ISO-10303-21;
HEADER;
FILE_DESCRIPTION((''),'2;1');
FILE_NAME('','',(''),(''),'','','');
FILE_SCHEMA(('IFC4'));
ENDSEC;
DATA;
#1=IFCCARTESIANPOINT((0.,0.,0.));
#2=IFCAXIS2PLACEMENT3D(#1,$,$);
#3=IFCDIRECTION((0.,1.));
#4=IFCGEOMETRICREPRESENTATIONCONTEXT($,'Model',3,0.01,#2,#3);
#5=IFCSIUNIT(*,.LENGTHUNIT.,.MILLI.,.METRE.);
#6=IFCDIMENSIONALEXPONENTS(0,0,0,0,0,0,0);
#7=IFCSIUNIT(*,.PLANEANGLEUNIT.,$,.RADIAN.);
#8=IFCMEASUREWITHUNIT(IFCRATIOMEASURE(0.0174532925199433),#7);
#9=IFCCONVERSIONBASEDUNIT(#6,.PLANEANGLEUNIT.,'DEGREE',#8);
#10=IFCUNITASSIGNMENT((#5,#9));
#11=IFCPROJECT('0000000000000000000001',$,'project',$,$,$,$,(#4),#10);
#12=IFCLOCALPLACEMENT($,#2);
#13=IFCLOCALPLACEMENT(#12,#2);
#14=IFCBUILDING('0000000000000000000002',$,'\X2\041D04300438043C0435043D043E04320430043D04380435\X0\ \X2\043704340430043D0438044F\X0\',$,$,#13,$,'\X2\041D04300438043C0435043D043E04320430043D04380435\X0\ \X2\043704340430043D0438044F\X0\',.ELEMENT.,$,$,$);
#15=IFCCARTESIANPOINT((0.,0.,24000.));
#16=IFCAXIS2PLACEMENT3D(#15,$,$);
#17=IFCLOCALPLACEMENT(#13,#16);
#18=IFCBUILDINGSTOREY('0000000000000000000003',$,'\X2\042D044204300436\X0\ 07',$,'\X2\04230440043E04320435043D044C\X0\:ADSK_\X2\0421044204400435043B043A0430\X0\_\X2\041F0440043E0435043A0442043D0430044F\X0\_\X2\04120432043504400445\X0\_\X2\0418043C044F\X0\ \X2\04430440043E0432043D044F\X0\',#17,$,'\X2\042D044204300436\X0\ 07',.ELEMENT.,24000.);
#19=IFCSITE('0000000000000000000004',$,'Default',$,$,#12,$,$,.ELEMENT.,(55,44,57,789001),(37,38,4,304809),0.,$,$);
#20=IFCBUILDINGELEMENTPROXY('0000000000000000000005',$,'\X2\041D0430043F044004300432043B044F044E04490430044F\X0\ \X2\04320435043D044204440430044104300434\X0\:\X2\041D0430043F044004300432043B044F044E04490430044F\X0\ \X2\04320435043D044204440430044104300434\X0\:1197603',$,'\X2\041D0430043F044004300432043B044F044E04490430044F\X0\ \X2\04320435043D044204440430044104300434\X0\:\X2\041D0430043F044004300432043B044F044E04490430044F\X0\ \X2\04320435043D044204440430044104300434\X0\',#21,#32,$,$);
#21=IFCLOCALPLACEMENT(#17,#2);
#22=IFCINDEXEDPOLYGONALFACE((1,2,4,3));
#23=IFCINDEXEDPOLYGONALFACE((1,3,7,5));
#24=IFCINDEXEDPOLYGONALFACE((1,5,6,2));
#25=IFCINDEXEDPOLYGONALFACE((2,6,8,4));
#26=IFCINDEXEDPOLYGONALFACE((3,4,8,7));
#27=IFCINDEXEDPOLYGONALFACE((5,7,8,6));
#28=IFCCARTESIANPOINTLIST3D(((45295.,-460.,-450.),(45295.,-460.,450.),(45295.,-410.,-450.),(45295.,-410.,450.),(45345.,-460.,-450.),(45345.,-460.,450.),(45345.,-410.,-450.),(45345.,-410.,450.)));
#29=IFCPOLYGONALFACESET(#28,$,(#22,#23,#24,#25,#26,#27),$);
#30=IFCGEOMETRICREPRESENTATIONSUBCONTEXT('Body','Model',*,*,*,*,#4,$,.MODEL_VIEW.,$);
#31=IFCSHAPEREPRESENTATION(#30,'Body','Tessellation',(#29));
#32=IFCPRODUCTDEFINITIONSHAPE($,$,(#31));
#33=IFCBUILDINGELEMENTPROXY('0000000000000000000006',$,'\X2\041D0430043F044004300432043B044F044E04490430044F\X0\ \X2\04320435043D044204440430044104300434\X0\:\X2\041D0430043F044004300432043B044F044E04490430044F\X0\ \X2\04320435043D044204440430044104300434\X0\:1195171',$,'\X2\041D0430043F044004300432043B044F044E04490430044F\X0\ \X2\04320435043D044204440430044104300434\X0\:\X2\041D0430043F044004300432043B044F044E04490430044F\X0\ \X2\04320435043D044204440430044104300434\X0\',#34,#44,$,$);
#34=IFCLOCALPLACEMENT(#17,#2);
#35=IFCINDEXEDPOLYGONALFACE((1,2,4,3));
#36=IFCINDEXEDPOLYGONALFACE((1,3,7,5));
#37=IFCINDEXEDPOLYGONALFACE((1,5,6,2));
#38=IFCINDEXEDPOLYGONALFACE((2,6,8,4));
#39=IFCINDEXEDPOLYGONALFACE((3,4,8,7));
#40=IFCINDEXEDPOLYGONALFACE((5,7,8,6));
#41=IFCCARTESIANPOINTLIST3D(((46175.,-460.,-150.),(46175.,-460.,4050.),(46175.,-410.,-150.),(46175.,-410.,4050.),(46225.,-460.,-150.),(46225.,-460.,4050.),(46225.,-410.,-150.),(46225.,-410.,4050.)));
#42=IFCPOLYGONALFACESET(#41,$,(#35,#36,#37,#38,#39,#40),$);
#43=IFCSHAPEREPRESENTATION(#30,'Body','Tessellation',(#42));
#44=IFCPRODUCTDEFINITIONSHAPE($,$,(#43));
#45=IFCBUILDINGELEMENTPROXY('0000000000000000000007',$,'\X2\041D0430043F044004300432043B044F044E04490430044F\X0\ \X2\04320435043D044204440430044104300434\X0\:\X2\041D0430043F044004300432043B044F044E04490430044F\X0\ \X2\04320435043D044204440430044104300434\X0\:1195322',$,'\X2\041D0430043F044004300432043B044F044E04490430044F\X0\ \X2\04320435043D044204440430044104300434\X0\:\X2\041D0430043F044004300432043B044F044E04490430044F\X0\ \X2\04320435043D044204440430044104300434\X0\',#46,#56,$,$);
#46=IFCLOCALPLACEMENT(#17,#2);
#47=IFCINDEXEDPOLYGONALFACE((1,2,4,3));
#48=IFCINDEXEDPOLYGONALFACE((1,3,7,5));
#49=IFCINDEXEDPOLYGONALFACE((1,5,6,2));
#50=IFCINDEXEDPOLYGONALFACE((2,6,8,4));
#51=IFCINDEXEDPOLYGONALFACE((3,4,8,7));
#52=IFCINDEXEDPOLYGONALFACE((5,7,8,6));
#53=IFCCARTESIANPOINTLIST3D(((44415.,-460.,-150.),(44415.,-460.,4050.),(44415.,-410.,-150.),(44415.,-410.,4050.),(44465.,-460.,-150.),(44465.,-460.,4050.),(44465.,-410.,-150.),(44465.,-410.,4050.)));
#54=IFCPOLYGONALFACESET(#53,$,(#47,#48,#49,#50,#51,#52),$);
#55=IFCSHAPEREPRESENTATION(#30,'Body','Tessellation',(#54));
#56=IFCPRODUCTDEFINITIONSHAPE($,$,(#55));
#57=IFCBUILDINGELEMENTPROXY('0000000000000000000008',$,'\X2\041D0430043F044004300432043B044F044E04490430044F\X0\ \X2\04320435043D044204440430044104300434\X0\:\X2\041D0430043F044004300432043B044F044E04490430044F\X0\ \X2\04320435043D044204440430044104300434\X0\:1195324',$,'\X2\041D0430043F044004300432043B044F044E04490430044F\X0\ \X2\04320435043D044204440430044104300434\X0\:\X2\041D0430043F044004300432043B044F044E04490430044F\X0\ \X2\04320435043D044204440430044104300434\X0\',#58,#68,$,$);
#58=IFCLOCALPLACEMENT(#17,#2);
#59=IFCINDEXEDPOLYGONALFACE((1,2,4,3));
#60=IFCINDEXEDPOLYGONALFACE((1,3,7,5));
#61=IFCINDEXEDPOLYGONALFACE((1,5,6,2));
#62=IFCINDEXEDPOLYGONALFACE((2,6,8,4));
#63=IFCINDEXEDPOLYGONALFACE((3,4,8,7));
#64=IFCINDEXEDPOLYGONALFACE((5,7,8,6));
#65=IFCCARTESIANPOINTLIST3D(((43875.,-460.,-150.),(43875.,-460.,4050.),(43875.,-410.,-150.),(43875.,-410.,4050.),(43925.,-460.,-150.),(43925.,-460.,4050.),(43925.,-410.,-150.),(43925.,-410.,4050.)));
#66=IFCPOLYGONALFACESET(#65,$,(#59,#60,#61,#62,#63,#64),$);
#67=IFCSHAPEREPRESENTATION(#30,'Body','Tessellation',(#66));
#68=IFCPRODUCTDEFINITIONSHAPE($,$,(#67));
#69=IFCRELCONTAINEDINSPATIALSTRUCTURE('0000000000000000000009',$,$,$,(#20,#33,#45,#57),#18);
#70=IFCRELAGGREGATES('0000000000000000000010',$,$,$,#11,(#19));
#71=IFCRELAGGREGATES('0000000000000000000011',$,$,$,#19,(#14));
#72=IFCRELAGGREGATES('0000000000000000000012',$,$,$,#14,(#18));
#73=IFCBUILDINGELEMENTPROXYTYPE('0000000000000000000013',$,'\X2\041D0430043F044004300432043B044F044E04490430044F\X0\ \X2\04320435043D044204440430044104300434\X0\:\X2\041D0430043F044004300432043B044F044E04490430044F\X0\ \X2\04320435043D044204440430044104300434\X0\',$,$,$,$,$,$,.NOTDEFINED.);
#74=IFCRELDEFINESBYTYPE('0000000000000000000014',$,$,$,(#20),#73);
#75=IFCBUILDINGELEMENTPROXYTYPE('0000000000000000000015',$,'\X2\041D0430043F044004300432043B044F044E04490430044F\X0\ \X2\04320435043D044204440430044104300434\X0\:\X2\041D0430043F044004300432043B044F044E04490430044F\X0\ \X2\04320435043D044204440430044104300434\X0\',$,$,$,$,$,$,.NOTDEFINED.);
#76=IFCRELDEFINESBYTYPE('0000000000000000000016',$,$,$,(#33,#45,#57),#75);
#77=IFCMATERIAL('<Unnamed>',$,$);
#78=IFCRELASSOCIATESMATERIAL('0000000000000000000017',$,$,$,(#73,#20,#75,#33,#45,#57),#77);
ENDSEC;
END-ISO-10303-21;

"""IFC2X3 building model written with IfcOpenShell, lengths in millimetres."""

from ifc_helpers import new_model, entity, si_unit, converted_unit, direction, frame, origin, origin_2d_with_axis, place, context, subcontext, project, spatial, rectangle, extrude, source, transform, mapped, material, type_object, type_shapes, element, save


model = new_model("IFC2X3")

# Units and contexts
model_context = context("Model", 3, precision=0.01, world=origin(), true_north=direction((0.0, 1.0)))
body_context = subcontext(model_context, "Body", "Model", "MODEL_VIEW")
ifc_project = project(units=[si_unit("LENGTHUNIT", "METRE", prefix="MILLI"), converted_unit("PLANEANGLEUNIT", "DEGREE", entity("IfcRatioMeasure", 0.0174532925199433), si_unit("PLANEANGLEUNIT", "RADIAN"), dimensions=[0, 0, 0, 0, 0, 0, 0])], contexts=[model_context])

# Site, building, storey
site_placement = place(None, origin())
site = spatial("IfcSite", under=ifc_project, at=site_placement, Name="Default", CompositionType="ELEMENT", RefLatitude=(55, 44, 57, 789001), RefLongitude=(37, 38, 4, 304809), RefElevation=0.0)
building_placement = place(site_placement, origin())
building = spatial("IfcBuilding", under=site, at=building_placement, Name="Наименование здания", LongName="Наименование здания", CompositionType="ELEMENT")
storey_placement = place(building_placement, frame((0.0, 0.0, 24000.0)))
storey = spatial("IfcBuildingStorey", under=building, at=storey_placement, Name="Этаж 07", ObjectType="Уровень:ADSK_Стрелка_Проектная_Вверх_Имя уровня", LongName="Этаж 07", CompositionType="ELEMENT", Elevation=24000.0)

# Building element proxies
ifc_material_1 = material(Name="<Unnamed>")
building_element_proxy_type_1 = type_object("IfcBuildingElementProxyType", Name="Направляющая вентфасад:Направляющая вентфасад", PredefinedType="NOTDEFINED", material=ifc_material_1)
shared_shape_1 = source(origin(), body_context, "Body", "SweptSolid", [
    extrude(rectangle(XDim=50.0, YDim=50.0, at=origin_2d_with_axis()), frame((25.0, -25.0, 0.0), z_axis=(0.0, 0.0, 1.0), x_axis=(-1.0, 0.0, 0.0)), (0.0, 0.0, 1.0), 900.0),
])
type_shapes(building_element_proxy_type_1, [shared_shape_1])
proxy_1_placement = place(storey_placement, frame((45295.0, -410.0, -450.0)))
element("IfcBuildingElementProxy", 1, at=proxy_1_placement, inside=storey, type_object=building_element_proxy_type_1, material=ifc_material_1, Name="Направляющая вентфасад:Направляющая вентфасад:1197603", ObjectType="Направляющая вентфасад:Направляющая вентфасад", context=body_context, shape_type="MappedRepresentation", body=[
    mapped(shared_shape_1, transform((0.0, 0.0, 0.0), scale=1.0)),
])
building_element_proxy_type_2 = type_object("IfcBuildingElementProxyType", Name="Направляющая вентфасад:Направляющая вентфасад", PredefinedType="NOTDEFINED", material=ifc_material_1)
shared_shape_2 = source(origin(), body_context, "Body", "SweptSolid", [
    extrude(rectangle(XDim=50.0, YDim=50.0, at=origin_2d_with_axis()), frame((25.0, -25.0, 0.0), z_axis=(0.0, 0.0, 1.0), x_axis=(-1.0, 0.0, 0.0)), (0.0, 0.0, 1.0), 4200.0),
])
type_shapes(building_element_proxy_type_2, [shared_shape_2])
for number, where, name in (
    (2, (46175.0, -410.0, -150.0), "Направляющая вентфасад:Направляющая вентфасад:1195171"),
    (3, (44415.0, -410.0, -150.0), "Направляющая вентфасад:Направляющая вентфасад:1195322"),
    (4, (43875.0, -410.0, -150.0), "Направляющая вентфасад:Направляющая вентфасад:1195324"),
):
    element("IfcBuildingElementProxy", number, at=place(storey_placement, frame(where)), inside=storey, type_object=building_element_proxy_type_2, material=ifc_material_1, Name=name, ObjectType="Направляющая вентфасад:Направляющая вентфасад", context=body_context, shape_type="MappedRepresentation", body=[
        mapped(shared_shape_2, transform((0.0, 0.0, 0.0), scale=1.0)),
    ])

save(model, "model.ifc")
